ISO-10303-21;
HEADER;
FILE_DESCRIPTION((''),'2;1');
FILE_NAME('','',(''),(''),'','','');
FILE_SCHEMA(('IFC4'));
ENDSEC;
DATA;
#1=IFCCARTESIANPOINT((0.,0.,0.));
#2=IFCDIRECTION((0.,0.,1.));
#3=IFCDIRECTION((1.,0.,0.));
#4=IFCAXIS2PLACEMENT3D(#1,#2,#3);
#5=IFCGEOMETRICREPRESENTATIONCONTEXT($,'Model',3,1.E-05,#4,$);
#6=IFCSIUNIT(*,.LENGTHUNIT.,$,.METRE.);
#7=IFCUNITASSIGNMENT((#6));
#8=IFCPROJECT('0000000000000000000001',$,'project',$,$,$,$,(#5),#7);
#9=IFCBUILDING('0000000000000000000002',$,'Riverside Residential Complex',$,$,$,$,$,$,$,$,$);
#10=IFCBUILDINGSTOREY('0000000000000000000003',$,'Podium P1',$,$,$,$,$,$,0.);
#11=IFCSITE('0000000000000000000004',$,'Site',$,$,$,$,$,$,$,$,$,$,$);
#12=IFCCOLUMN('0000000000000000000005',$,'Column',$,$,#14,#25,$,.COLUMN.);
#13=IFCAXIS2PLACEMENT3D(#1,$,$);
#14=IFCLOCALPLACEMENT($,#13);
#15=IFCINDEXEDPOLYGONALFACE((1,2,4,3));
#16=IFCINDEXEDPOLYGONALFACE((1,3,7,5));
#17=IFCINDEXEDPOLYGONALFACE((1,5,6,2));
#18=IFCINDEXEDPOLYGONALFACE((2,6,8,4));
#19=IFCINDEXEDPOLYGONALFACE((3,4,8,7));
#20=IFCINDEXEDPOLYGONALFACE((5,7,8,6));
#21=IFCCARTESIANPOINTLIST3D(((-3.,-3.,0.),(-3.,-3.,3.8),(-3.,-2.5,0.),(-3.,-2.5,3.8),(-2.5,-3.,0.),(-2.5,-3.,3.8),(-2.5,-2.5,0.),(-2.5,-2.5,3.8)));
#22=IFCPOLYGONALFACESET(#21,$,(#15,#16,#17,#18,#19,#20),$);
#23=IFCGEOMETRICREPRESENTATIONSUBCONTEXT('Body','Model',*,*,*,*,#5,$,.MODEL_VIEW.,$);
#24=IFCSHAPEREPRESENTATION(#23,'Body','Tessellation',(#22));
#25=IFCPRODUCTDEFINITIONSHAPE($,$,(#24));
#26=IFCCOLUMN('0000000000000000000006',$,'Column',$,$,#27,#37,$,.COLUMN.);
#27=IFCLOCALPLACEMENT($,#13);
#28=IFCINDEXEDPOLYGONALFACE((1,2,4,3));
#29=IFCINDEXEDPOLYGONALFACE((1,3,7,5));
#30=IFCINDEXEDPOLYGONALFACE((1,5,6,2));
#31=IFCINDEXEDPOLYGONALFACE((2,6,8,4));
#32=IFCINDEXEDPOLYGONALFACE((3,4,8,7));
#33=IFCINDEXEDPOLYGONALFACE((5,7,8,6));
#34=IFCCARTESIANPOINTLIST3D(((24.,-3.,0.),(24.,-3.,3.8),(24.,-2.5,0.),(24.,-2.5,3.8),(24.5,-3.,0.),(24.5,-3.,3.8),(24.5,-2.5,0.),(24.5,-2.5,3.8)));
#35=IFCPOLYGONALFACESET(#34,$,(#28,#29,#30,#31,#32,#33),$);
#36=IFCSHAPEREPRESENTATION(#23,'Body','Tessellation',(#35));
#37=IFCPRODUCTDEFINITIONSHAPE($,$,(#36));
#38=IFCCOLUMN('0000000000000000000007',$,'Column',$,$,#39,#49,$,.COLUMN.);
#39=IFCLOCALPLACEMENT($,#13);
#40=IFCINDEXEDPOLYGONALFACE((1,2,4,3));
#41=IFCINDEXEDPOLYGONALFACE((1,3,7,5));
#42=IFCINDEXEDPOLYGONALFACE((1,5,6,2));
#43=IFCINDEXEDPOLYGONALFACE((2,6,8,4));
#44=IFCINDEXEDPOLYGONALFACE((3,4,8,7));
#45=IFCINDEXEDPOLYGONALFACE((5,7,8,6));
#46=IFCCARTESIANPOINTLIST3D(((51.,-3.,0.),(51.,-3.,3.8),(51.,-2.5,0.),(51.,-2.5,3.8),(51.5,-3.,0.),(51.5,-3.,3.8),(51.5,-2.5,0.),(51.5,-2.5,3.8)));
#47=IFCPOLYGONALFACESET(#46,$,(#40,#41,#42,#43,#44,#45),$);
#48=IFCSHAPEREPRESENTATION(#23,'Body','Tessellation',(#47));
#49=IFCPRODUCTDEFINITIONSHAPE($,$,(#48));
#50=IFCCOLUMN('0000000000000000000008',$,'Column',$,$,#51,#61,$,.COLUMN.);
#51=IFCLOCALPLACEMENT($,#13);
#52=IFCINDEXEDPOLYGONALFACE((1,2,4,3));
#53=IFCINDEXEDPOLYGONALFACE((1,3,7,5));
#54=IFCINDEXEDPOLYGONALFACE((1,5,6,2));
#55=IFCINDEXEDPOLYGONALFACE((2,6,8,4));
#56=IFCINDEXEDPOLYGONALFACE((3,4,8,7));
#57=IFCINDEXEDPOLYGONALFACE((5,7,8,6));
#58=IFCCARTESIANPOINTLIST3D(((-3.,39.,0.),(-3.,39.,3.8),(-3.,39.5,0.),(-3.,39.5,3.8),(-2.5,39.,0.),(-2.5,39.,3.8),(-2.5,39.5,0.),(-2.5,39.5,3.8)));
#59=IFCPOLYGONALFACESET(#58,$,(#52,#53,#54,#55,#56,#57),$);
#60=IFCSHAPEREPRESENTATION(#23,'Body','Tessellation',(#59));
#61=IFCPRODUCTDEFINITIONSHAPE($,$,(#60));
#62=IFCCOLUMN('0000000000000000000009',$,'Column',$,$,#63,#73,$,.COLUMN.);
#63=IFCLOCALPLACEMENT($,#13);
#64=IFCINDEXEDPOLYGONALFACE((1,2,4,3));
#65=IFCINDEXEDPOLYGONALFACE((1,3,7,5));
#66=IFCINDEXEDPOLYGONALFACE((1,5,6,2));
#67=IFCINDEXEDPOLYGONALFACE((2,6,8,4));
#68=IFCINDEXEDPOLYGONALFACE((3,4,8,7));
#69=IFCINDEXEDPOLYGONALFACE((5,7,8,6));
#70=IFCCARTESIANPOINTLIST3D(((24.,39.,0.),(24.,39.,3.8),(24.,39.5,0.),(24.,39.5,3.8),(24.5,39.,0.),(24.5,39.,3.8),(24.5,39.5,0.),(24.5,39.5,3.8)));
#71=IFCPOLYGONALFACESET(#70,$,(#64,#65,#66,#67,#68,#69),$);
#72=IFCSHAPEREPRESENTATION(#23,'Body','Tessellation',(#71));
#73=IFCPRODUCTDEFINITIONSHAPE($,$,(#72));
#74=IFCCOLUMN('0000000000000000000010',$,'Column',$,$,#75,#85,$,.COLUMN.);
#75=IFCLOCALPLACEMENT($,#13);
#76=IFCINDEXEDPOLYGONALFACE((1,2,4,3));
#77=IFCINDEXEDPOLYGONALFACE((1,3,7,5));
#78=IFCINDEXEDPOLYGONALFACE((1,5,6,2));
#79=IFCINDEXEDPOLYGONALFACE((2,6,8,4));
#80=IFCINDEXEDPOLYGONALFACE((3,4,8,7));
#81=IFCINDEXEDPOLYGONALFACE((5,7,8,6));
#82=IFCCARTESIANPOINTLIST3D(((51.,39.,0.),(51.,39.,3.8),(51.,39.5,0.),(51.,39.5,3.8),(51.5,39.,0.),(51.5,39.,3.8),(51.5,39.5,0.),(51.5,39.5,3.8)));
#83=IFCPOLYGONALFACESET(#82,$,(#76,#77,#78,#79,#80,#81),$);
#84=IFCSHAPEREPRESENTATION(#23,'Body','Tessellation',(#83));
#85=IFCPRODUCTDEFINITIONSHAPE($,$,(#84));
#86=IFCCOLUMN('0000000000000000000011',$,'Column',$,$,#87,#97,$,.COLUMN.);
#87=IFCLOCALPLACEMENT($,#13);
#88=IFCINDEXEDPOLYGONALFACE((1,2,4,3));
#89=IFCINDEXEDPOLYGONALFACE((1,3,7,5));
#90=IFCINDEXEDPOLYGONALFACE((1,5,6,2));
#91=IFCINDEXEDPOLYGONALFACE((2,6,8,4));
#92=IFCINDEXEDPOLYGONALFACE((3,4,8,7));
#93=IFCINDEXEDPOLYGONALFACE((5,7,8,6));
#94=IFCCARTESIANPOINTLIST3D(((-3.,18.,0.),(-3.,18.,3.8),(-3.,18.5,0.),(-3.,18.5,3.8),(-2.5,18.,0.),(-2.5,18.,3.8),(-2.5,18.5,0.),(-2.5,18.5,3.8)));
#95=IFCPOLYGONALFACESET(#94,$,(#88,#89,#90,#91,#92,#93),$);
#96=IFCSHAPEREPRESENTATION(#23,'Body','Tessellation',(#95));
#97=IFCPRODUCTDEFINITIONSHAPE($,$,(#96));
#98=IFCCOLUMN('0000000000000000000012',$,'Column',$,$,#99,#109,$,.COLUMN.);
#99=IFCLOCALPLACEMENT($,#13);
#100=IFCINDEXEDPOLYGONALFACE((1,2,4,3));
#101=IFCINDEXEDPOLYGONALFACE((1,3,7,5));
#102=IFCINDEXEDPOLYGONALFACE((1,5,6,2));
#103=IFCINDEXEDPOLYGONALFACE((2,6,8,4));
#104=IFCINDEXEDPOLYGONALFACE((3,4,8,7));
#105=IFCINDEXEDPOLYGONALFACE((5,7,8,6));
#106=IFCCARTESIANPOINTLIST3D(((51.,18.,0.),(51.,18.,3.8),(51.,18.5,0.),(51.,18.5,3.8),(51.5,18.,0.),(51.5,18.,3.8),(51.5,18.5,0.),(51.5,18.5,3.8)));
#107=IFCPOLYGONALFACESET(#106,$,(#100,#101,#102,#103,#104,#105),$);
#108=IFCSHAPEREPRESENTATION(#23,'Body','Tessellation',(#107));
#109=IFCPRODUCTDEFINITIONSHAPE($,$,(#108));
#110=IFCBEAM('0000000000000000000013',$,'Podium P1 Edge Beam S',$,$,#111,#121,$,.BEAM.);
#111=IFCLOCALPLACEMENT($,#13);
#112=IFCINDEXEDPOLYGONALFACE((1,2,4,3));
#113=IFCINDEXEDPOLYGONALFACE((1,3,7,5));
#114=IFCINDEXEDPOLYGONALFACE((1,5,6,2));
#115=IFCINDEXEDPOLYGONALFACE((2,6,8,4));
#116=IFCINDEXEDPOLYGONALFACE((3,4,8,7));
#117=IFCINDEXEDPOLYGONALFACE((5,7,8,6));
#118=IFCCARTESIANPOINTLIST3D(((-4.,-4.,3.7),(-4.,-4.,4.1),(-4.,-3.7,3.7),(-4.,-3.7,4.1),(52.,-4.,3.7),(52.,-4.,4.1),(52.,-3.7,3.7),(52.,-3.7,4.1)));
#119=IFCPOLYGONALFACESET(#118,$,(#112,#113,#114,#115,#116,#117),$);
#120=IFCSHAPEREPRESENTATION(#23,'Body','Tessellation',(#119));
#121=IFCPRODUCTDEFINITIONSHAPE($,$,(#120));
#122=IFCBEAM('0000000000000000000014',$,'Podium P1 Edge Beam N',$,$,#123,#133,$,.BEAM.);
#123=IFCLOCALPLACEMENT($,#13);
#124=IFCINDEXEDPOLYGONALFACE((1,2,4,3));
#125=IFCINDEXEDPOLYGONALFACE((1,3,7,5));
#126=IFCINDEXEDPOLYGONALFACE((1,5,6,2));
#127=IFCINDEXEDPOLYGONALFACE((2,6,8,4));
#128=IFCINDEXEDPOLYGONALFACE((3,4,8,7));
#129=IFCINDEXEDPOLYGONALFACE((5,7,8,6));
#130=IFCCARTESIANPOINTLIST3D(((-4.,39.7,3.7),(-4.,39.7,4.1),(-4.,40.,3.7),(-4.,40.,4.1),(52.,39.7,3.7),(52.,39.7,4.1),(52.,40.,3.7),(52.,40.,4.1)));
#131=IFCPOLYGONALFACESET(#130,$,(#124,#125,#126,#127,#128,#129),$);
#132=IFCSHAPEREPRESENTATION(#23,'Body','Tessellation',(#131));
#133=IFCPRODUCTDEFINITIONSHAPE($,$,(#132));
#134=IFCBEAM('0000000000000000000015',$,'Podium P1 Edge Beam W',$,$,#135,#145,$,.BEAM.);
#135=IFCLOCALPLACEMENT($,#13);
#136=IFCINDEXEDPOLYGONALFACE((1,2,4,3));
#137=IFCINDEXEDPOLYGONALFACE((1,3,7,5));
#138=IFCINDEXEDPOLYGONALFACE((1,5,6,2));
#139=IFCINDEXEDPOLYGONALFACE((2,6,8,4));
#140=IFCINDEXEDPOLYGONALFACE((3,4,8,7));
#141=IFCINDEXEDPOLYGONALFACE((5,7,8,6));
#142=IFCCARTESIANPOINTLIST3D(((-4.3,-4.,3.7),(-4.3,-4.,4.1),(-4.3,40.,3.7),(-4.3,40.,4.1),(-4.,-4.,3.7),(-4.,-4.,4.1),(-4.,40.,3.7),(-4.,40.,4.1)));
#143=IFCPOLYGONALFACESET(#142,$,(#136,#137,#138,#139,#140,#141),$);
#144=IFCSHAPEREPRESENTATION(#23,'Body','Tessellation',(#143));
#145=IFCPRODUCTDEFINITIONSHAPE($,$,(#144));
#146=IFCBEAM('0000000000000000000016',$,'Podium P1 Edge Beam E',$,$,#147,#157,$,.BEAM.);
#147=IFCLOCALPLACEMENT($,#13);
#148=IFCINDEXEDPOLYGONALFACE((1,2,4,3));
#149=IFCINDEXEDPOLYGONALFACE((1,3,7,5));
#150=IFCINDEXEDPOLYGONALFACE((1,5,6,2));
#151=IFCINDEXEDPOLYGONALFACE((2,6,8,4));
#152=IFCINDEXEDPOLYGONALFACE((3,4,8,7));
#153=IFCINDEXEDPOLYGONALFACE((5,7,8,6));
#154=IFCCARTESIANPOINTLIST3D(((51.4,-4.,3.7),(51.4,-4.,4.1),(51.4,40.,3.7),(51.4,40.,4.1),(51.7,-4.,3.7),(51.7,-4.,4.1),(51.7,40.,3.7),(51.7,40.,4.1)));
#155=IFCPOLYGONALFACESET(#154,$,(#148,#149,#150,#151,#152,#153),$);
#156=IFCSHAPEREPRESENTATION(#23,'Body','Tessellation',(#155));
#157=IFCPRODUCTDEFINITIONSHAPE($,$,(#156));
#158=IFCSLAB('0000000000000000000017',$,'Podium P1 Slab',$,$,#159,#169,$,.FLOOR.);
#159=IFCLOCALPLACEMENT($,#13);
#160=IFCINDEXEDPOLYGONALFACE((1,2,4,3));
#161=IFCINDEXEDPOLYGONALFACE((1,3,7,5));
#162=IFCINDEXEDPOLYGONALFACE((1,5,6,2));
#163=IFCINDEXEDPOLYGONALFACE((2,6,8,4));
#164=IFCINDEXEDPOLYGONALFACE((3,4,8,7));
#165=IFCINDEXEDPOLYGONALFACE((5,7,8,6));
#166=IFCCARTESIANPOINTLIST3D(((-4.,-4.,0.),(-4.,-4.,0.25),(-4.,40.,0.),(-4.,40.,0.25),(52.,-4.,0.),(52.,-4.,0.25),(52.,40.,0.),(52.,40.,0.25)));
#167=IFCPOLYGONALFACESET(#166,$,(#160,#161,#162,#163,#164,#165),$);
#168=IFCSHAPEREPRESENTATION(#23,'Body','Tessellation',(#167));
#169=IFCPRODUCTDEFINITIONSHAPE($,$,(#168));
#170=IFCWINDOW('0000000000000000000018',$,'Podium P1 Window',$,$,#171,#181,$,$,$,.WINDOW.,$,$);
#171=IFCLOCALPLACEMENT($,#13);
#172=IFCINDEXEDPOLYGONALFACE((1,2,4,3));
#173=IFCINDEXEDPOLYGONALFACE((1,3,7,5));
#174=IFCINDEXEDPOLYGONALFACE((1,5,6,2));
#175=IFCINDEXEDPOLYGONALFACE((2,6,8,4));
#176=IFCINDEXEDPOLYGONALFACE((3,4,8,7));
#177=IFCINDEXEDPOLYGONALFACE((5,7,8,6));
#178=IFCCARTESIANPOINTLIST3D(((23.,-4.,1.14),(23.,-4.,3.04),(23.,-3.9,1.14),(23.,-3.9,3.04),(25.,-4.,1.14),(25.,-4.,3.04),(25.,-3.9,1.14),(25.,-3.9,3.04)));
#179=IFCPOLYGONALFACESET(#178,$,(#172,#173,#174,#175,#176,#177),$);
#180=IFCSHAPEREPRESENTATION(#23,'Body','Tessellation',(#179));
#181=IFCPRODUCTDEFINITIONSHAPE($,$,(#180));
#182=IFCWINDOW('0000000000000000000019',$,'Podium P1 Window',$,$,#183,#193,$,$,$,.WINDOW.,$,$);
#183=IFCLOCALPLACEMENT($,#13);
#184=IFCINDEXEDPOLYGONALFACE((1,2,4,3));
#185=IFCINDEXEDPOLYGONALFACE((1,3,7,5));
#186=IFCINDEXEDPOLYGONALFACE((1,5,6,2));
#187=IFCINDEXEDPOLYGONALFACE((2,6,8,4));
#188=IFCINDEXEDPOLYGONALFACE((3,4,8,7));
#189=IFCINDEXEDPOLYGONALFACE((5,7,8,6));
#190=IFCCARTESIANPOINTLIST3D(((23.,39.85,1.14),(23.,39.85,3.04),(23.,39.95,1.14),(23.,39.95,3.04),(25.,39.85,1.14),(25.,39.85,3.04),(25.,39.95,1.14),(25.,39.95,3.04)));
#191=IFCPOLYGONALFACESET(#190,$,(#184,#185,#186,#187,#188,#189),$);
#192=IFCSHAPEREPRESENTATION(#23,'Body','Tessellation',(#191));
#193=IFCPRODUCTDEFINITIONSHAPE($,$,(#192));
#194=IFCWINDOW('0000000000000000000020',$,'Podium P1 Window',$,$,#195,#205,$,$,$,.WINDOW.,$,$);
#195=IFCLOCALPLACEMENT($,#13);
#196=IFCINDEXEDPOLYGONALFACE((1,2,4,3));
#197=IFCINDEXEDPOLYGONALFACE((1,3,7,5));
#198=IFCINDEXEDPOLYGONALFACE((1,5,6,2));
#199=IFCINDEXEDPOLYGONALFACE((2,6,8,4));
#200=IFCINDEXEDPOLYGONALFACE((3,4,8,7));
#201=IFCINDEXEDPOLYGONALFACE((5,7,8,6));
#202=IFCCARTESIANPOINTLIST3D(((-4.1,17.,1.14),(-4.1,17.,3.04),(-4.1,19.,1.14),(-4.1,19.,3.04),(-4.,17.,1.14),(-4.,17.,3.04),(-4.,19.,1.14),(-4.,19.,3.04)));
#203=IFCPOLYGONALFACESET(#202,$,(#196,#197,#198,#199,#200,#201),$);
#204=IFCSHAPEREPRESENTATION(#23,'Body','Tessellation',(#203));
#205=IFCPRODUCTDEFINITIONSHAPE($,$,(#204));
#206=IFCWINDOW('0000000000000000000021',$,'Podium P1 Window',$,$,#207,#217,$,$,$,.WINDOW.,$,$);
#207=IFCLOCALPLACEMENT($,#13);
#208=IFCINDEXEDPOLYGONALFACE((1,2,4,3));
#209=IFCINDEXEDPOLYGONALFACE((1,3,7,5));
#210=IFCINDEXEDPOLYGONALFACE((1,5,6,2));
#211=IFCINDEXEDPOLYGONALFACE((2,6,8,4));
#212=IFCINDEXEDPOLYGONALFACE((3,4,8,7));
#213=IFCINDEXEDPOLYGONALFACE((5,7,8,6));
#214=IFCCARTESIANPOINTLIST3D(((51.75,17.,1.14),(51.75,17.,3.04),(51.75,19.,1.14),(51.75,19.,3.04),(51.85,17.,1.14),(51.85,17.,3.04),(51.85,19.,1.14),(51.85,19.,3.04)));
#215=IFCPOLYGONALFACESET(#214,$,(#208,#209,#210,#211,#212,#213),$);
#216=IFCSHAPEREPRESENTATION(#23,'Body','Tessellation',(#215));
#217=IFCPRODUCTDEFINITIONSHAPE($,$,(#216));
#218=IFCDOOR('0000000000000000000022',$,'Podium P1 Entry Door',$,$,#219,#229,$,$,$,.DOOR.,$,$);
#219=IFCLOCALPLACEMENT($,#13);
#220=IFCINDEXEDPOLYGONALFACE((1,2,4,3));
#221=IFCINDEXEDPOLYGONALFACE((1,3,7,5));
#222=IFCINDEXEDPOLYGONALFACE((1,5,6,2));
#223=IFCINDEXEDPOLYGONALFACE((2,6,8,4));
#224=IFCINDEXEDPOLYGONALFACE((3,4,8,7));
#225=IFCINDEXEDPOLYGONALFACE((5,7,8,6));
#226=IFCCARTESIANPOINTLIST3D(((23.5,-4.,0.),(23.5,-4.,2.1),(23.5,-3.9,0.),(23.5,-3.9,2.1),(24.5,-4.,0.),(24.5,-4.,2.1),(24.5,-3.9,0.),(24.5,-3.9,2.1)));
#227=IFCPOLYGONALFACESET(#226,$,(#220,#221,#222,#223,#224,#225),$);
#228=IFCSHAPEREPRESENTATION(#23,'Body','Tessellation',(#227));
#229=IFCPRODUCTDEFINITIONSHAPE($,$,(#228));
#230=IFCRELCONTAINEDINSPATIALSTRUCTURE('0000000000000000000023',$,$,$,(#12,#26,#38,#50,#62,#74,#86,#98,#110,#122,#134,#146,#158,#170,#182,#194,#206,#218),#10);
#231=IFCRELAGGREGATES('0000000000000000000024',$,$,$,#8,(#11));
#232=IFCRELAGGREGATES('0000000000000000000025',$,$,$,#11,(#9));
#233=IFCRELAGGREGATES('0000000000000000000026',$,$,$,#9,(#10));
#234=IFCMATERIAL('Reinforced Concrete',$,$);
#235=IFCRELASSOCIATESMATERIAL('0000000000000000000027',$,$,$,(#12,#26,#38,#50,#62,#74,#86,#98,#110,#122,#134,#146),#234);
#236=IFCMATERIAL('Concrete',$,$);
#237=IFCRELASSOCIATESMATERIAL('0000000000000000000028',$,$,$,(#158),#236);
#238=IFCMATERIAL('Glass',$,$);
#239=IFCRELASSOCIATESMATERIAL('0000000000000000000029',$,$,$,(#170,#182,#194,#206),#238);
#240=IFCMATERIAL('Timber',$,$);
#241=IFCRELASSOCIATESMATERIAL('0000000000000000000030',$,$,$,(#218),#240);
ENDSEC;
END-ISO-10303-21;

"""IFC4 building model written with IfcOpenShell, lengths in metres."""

from ifc_helpers import new_model, si_unit, frame, origin_with_axes, place, context, subcontext, project, spatial, line, indexed_curve, outline, extrude, material, element, save


model = new_model("IFC4")

# Units and contexts
model_context = context("Model", 3, precision=1e-05, world=origin_with_axes())
body_context = subcontext(model_context, "Body", "Model", "MODEL_VIEW")
ifc_project = project(units=[si_unit("LENGTHUNIT", "METRE")], contexts=[model_context])

# Site, building, storey
site = spatial("IfcSite", under=ifc_project, Name="Site")
building = spatial("IfcBuilding", under=site, Name="Riverside Residential Complex")
storey = spatial("IfcBuildingStorey", under=building, Name="Podium P1", Elevation=0.0)

# Columns
ifc_material_1 = material(Name="Reinforced Concrete")
for number, where, z_axis, x_axis, name in (
    (1, (-3.0, -3.0, 0.0), (0.0, 0.0, 1.0), (1.0, 0.0, 0.0), "Column"),
    (2, (24.0, -3.0, 0.0), (0.0, 0.0, 1.0), (1.0, 0.0, 0.0), "Column"),
    (3, (51.0, -3.0, 0.0), (0.0, 0.0, 1.0), (1.0, 0.0, 0.0), "Column"),
    (4, (-3.0, 39.0, 0.0), (0.0, 0.0, 1.0), (1.0, 0.0, 0.0), "Column"),
    (5, (24.0, 39.0, 0.0), (0.0, 0.0, 1.0), (1.0, 0.0, 0.0), "Column"),
    (6, (51.0, 39.0, 0.0), (0.0, 0.0, 1.0), (1.0, 0.0, 0.0), "Column"),
    (7, (-3.0, 18.0, 0.0), (0.0, 0.0, 1.0), (1.0, 0.0, 0.0), "Column"),
    (8, (51.0, 18.0, 0.0), (0.0, 0.0, 1.0), (1.0, 0.0, 0.0), "Column"),
):
    element("IfcColumn", number, at=place(None, frame(where, z_axis=z_axis, x_axis=x_axis)), inside=storey, material=ifc_material_1, Name=name, PredefinedType="COLUMN", context=body_context, shape_type="SweptSolid", body=[
        extrude(outline(indexed_curve([(0.0, 0.0), (0.5, 0.0), (0.5, 0.5), (0.0, 0.5)], segments=[line(1, 2, 3, 4, 1)])), origin_with_axes(), (0.0, 0.0, 1.0), 3.8),
    ])

# Beams
for number, where, z_axis, x_axis, name in (
    (9, (-4.0, -4.0, 3.7), (0.0, 0.0, 1.0), (1.0, 0.0, 0.0), "Podium P1 Edge Beam S"),
    (10, (-4.0, 39.7, 3.7), (0.0, 0.0, 1.0), (1.0, 0.0, 0.0), "Podium P1 Edge Beam N"),
):
    element("IfcBeam", number, at=place(None, frame(where, z_axis=z_axis, x_axis=x_axis)), inside=storey, material=ifc_material_1, Name=name, PredefinedType="BEAM", context=body_context, shape_type="SweptSolid", body=[
        extrude(outline(indexed_curve([(0.0, 0.0), (56.0, 0.0), (56.0, 0.3), (0.0, 0.3)], segments=[line(1, 2, 3, 4, 1)])), origin_with_axes(), (0.0, 0.0, 1.0), 0.4),
    ])
for number, where, z_axis, x_axis, name in (
    (11, (-4.0, -4.0, 3.7), (0.0, 0.0, 1.0), (0.0, 1.0, 0.0), "Podium P1 Edge Beam W"),
    (12, (51.7, -4.0, 3.7), (0.0, 0.0, 1.0), (0.0, 1.0, 0.0), "Podium P1 Edge Beam E"),
):
    element("IfcBeam", number, at=place(None, frame(where, z_axis=z_axis, x_axis=x_axis)), inside=storey, material=ifc_material_1, Name=name, PredefinedType="BEAM", context=body_context, shape_type="SweptSolid", body=[
        extrude(outline(indexed_curve([(0.0, 0.0), (44.0, 0.0), (44.0, 0.3), (0.0, 0.3)], segments=[line(1, 2, 3, 4, 1)])), origin_with_axes(), (0.0, 0.0, 1.0), 0.4),
    ])

# Slab
ifc_material_2 = material(Name="Concrete")
slab_placement = place(None, frame((-4.0, -4.0, 0.0), z_axis=(0.0, 0.0, 1.0), x_axis=(1.0, 0.0, 0.0)))
element("IfcSlab", 13, at=slab_placement, inside=storey, material=ifc_material_2, Name="Podium P1 Slab", PredefinedType="FLOOR", context=body_context, shape_type="SweptSolid", body=[
    extrude(outline(indexed_curve([(0.0, 0.0), (56.0, 0.0), (56.0, 44.0), (0.0, 44.0)], segments=[line(1, 2, 3, 4, 1)])), origin_with_axes(), (0.0, 0.0, 1.0), 0.25),
])

# Windows
ifc_material_3 = material(Name="Glass")
for number, where, z_axis, x_axis, name in (
    (14, (23.0, -4.0, 1.14), (0.0, 0.0, 1.0), (1.0, 0.0, 0.0), "Podium P1 Window"),
    (15, (23.0, 39.85, 1.14), (0.0, 0.0, 1.0), (1.0, 0.0, 0.0), "Podium P1 Window"),
    (16, (-4.0, 17.0, 1.14), (0.0, 0.0, 1.0), (0.0, 1.0, 0.0), "Podium P1 Window"),
    (17, (51.85, 17.0, 1.14), (0.0, 0.0, 1.0), (0.0, 1.0, 0.0), "Podium P1 Window"),
):
    element("IfcWindow", number, at=place(None, frame(where, z_axis=z_axis, x_axis=x_axis)), inside=storey, material=ifc_material_3, Name=name, PredefinedType="WINDOW", context=body_context, shape_type="SweptSolid", body=[
        extrude(outline(indexed_curve([(0.0, 0.0), (2.0, 0.0), (2.0, 0.1), (0.0, 0.1)], segments=[line(1, 2, 3, 4, 1)])), origin_with_axes(), (0.0, 0.0, 1.0), 1.9),
    ])

# Door
ifc_material_4 = material(Name="Timber")
door_placement = place(None, frame((23.5, -4.0, 0.0), z_axis=(0.0, 0.0, 1.0), x_axis=(1.0, 0.0, 0.0)))
element("IfcDoor", 18, at=door_placement, inside=storey, material=ifc_material_4, Name="Podium P1 Entry Door", PredefinedType="DOOR", context=body_context, shape_type="SweptSolid", body=[
    extrude(outline(indexed_curve([(0.0, 0.0), (1.0, 0.0), (1.0, 0.1), (0.0, 0.1)], segments=[line(1, 2, 3, 4, 1)])), origin_with_axes(), (0.0, 0.0, 1.0), 2.1),
])

save(model, "model.ifc")
